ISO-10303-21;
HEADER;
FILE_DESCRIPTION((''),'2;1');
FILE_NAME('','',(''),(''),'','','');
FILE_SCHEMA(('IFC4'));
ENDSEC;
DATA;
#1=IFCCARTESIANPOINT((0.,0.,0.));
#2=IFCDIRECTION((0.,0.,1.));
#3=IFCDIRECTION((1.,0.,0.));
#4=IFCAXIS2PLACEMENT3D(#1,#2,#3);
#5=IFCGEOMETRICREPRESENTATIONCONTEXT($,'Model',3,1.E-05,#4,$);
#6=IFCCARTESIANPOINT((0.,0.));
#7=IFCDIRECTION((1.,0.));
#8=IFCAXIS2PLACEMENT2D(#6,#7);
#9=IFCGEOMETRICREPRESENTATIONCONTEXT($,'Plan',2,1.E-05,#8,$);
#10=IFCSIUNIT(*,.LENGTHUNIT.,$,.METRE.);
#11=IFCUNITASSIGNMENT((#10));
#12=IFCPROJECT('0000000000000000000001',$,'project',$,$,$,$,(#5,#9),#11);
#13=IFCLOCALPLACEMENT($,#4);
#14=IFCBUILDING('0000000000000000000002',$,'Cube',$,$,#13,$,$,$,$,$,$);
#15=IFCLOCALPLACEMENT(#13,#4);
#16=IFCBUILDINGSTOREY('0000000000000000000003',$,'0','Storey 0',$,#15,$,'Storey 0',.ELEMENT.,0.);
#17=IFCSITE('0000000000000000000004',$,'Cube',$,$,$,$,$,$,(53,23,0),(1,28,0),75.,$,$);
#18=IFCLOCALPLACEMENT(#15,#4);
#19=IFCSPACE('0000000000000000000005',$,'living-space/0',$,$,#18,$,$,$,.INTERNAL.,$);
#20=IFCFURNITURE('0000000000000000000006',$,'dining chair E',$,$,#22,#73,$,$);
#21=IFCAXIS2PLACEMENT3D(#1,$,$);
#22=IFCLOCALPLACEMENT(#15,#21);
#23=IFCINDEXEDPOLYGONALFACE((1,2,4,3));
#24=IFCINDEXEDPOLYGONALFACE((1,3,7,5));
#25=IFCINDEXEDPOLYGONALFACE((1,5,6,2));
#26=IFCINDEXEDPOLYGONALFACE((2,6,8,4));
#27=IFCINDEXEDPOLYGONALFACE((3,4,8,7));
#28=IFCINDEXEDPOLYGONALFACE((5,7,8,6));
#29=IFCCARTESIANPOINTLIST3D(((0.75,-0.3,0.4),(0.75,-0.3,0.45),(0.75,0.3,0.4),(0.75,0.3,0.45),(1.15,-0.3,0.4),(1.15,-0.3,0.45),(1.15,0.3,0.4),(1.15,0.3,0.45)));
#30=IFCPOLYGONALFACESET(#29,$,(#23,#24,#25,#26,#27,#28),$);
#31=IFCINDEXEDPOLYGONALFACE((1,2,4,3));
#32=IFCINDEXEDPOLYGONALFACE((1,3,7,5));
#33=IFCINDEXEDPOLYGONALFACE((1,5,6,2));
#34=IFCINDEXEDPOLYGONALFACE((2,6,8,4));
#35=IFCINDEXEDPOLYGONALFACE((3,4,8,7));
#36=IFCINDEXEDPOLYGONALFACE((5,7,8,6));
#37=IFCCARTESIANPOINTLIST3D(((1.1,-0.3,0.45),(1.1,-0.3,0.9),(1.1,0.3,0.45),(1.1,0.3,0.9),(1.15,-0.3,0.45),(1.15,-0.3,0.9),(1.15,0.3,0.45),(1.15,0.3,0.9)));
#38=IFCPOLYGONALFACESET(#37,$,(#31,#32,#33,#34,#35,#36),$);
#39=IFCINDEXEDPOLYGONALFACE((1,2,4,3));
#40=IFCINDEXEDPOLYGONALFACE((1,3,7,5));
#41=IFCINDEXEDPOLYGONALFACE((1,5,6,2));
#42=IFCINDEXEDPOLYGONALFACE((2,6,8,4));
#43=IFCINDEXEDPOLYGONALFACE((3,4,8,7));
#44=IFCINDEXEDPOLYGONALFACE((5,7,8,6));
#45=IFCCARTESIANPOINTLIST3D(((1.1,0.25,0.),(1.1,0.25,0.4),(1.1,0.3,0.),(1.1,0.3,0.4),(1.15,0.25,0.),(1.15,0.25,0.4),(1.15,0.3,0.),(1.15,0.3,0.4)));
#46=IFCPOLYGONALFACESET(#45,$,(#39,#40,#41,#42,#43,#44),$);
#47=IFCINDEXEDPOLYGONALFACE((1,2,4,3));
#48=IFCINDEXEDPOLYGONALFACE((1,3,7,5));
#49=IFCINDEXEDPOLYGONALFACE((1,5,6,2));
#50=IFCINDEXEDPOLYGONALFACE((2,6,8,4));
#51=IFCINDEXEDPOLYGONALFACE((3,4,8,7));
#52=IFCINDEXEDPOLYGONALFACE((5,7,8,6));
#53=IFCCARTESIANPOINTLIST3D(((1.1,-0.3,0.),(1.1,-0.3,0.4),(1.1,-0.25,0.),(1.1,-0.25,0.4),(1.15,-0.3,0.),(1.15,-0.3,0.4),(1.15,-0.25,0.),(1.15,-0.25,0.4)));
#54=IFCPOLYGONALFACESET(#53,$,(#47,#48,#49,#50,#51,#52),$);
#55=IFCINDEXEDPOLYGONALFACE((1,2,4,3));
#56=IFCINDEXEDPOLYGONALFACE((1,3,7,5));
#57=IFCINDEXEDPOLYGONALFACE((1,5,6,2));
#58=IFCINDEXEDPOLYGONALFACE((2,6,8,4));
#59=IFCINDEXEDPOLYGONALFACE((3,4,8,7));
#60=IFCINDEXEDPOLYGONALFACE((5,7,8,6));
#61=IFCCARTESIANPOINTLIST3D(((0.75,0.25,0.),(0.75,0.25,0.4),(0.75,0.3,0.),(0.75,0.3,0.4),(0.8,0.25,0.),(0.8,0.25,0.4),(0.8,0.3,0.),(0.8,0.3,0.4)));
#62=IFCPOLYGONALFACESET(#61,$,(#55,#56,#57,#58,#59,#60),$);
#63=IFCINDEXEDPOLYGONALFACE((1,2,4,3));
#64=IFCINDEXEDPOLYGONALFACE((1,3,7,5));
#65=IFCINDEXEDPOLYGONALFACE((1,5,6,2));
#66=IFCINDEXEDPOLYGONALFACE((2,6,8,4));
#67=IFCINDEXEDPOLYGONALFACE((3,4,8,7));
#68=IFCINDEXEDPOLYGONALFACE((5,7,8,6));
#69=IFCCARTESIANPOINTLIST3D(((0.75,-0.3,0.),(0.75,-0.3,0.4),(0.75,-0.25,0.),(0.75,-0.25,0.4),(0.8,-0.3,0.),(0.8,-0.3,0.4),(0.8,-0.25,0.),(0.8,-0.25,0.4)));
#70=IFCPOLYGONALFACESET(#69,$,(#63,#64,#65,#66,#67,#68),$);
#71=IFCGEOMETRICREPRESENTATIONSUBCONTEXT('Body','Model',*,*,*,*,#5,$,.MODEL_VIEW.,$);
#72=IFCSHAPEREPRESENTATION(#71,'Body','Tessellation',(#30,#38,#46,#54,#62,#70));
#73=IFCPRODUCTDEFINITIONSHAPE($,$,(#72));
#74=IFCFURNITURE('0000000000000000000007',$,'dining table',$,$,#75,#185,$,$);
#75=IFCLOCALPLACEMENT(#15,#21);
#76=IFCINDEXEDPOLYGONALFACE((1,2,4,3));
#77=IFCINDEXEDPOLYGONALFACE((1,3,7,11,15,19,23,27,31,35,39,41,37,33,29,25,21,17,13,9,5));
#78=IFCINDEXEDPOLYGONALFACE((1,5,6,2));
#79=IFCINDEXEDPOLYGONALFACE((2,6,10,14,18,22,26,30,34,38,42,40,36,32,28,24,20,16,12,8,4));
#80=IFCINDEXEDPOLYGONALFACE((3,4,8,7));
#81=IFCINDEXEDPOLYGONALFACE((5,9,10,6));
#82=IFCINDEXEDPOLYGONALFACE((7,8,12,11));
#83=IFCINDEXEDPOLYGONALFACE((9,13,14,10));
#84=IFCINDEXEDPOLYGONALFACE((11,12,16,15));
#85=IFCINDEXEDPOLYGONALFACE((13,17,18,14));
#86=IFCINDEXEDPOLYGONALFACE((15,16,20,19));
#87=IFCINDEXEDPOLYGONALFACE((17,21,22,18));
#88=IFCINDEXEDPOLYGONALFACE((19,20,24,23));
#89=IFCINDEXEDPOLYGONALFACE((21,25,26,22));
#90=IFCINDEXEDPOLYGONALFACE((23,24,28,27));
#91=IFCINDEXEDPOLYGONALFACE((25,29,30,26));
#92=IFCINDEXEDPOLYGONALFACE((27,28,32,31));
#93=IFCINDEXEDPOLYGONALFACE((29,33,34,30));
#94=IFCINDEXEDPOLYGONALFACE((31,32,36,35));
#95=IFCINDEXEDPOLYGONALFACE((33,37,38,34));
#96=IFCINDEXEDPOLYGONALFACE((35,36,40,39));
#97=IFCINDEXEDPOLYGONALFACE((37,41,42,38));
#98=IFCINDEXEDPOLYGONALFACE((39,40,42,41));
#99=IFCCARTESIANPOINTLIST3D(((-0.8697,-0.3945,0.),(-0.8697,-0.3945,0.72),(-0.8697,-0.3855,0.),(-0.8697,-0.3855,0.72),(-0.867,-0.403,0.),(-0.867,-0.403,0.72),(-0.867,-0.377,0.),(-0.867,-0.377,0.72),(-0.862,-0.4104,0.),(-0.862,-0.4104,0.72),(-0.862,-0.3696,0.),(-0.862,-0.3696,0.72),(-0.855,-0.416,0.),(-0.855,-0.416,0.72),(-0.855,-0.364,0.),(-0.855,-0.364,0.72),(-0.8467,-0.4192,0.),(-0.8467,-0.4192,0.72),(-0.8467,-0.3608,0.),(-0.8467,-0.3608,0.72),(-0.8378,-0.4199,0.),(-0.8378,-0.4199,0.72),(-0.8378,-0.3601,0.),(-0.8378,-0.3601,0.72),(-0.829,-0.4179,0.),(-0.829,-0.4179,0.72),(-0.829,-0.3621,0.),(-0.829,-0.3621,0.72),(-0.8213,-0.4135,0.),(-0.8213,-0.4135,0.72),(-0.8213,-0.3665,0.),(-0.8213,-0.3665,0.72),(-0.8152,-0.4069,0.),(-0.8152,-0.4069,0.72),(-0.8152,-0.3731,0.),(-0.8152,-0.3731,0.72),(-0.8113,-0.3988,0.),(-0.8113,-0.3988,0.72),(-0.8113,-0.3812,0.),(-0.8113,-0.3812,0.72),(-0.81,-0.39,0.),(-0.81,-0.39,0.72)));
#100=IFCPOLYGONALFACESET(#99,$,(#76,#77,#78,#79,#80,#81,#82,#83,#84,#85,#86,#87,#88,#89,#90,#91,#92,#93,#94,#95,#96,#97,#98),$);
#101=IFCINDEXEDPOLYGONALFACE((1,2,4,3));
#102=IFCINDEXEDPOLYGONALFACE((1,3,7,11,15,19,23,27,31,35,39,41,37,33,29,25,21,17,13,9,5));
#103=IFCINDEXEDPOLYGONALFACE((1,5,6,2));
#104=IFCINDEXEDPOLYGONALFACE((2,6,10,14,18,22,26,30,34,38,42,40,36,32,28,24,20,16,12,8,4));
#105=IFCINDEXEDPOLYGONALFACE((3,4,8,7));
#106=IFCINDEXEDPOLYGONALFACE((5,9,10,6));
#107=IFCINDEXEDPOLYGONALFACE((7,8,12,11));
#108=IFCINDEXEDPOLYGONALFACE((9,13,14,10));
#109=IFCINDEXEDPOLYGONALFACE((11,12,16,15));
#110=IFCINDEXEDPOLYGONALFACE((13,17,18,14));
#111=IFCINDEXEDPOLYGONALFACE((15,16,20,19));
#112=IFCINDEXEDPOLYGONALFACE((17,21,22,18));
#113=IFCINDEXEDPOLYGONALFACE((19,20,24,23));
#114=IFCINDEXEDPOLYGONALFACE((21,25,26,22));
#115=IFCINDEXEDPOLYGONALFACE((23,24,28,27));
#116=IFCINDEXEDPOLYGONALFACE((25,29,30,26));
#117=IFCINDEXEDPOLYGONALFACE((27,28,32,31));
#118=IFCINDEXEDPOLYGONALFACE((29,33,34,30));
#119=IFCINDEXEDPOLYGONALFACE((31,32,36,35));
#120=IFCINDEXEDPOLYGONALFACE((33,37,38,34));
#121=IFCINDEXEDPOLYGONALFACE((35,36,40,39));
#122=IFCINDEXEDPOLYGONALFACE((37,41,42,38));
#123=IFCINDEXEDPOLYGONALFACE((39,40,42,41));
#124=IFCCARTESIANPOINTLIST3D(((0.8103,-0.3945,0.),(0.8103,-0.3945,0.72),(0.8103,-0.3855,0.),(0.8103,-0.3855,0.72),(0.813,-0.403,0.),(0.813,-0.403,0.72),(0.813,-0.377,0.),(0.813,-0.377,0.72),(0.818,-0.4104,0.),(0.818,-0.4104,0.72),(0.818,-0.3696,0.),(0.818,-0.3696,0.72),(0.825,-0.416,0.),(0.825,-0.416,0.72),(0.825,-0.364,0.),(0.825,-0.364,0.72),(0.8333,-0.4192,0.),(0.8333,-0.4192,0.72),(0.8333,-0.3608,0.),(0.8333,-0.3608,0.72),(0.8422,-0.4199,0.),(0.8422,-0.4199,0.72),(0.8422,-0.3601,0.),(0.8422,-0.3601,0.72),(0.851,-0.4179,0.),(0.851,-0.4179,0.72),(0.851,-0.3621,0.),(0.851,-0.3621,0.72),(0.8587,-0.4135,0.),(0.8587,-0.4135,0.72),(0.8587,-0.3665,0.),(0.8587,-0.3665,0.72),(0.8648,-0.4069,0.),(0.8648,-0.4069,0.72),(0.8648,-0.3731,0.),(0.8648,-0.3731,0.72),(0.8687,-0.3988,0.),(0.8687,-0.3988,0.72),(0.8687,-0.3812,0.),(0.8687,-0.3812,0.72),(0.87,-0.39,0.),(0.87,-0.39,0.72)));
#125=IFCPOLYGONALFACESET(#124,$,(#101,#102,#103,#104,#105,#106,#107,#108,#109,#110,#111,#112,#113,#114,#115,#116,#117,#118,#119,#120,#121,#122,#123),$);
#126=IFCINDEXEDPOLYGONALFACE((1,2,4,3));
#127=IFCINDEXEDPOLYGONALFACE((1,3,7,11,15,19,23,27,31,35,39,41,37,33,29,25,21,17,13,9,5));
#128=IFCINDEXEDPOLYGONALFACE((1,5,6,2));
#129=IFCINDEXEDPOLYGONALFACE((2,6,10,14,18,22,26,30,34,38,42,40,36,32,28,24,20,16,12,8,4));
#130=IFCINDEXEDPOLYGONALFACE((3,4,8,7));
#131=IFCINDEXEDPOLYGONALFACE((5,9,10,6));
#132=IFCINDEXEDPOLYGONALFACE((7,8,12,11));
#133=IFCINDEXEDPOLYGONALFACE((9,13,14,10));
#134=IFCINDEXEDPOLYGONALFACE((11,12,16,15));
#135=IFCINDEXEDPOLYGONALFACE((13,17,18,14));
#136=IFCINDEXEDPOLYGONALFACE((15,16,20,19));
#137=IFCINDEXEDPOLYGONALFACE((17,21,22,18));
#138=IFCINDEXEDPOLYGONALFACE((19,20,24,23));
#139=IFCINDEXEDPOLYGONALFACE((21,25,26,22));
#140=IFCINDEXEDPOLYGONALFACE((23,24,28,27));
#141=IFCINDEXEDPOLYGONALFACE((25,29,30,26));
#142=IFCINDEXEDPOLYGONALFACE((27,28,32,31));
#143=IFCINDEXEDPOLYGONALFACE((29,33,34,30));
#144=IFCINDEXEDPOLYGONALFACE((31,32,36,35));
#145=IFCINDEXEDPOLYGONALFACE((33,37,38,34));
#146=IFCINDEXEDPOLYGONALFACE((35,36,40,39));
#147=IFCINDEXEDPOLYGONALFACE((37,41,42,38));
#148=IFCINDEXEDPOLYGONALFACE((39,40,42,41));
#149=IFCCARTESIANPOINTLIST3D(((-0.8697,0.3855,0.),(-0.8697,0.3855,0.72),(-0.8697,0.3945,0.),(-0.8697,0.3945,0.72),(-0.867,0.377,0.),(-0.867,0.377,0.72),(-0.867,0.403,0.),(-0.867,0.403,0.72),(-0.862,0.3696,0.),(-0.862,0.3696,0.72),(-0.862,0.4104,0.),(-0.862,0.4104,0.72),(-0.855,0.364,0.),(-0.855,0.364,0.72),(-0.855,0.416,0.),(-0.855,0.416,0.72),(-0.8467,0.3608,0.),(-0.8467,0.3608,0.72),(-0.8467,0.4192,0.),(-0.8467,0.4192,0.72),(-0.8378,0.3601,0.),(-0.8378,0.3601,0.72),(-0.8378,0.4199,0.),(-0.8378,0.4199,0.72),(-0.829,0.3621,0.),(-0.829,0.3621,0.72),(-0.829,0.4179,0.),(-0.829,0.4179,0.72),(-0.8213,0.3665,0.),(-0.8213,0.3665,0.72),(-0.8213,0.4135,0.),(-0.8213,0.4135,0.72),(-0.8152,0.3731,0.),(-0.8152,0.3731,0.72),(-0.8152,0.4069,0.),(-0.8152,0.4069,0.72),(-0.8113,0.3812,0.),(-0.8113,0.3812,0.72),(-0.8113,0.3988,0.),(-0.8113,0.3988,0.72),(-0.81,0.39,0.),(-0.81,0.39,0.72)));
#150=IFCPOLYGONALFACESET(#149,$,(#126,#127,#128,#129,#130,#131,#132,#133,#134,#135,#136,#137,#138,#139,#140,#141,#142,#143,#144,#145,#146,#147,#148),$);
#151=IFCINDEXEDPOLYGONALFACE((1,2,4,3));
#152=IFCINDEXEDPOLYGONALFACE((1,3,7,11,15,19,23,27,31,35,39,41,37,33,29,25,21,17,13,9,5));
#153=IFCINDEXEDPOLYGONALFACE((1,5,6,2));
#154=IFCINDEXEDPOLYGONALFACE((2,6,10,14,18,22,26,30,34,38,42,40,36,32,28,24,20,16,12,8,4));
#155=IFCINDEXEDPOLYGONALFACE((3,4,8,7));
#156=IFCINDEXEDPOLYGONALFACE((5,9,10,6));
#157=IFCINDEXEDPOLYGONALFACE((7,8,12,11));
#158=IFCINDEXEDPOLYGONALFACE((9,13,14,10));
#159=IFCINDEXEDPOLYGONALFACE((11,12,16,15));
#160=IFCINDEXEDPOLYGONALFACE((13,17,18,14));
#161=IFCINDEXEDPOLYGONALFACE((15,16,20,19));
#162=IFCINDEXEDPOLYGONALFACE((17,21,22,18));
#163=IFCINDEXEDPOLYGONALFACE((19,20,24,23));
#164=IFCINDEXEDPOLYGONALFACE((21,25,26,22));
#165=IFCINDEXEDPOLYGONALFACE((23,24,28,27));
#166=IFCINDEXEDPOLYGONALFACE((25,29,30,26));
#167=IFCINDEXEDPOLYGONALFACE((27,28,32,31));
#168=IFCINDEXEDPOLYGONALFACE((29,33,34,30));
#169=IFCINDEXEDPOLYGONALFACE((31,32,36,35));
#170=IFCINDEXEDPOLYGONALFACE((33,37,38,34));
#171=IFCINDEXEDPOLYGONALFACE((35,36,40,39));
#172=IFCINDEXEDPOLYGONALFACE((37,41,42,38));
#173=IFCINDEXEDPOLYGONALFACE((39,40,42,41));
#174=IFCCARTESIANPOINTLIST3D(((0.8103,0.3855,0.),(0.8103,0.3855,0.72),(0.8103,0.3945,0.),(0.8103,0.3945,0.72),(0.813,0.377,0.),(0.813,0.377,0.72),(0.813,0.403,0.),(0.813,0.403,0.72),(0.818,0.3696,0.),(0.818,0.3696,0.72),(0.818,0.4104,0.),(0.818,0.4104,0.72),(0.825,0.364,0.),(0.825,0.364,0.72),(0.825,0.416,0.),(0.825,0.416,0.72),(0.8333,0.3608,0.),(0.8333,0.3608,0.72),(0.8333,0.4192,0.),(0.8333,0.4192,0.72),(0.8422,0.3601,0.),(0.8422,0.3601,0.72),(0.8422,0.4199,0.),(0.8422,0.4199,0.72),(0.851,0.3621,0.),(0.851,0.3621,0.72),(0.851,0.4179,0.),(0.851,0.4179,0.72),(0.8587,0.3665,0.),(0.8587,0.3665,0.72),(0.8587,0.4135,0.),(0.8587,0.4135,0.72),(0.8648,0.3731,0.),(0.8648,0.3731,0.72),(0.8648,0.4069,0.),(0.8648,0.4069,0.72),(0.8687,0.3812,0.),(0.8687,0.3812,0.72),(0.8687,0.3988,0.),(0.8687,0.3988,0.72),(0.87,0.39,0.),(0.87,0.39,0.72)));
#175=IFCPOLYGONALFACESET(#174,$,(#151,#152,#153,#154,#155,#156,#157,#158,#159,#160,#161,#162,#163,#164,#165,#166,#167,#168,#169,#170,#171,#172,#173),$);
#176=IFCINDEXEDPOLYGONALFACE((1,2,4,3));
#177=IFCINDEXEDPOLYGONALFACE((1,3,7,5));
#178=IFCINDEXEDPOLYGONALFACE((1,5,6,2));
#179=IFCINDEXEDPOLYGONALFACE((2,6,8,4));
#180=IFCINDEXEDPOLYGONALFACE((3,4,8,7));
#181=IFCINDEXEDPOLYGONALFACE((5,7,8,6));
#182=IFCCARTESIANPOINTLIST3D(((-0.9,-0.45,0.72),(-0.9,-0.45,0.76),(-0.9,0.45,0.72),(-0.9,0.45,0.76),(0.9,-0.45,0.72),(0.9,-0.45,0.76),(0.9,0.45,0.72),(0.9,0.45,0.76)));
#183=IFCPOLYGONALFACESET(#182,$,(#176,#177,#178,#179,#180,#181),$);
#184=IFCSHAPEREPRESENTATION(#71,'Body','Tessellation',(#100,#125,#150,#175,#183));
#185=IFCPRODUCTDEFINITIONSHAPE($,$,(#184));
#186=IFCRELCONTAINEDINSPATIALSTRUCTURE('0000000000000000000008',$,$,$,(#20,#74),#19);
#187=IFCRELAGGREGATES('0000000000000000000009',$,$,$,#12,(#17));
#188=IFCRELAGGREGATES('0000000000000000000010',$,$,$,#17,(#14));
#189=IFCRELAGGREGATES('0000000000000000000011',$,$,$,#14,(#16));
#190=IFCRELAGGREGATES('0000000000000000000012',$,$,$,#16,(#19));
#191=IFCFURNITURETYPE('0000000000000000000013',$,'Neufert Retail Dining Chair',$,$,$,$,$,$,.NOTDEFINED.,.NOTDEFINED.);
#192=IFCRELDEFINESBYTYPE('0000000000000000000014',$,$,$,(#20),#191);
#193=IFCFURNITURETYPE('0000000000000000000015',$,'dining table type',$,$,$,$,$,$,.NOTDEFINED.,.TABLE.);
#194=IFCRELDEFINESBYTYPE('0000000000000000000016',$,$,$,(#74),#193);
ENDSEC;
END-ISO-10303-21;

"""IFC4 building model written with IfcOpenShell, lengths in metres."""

from ifc_helpers import new_model, entity, si_unit, frame, origin_with_axes, origin_2d_with_axis, place, context, subcontext, project, spatial, line, indexed_curve, outline, extrude, shape, source, transform, mapped, type_object, type_shapes, element, save


model = new_model("IFC4")

# Units and contexts
model_context = context("Model", 3, precision=1e-05, world=origin_with_axes())
plan_context = context("Plan", 2, precision=1e-05, world=origin_2d_with_axis())
body_context_1 = subcontext(model_context, "Body", "Model", "MODEL_VIEW")
body_context_2 = subcontext(plan_context, "Body", "Plan", "PLAN_VIEW")
ifc_project = project(units=[si_unit("LENGTHUNIT", "METRE")], contexts=[model_context, plan_context])

# Site, building, storey
site = spatial("IfcSite", under=ifc_project, Name="Cube", RefLatitude=(53, 23, 0), RefLongitude=(1, 28, 0), RefElevation=75.0)
building_placement = place(None, origin_with_axes())
building = spatial("IfcBuilding", under=site, at=building_placement, Name="Cube")
storey_placement = place(building_placement, origin_with_axes())
storey = spatial("IfcBuildingStorey", under=building, at=storey_placement, Name="0", Description="Storey 0", LongName="Storey 0", CompositionType="ELEMENT", Elevation=0.0)

# Shared definitions
space_placement = place(storey_placement, origin_with_axes())
space = spatial("IfcSpace", under=storey, at=space_placement, Name="living-space/0", PredefinedType="INTERNAL")

# Furniture
furniture_type_1 = type_object("IfcFurnitureType", Name="Neufert Retail Dining Chair", AssemblyPlace="NOTDEFINED", PredefinedType="NOTDEFINED")
shared_shape_1 = source(origin_with_axes(), body_context_1, "Body", "SweptSolid", [
    extrude(outline(indexed_curve([(-0.3, 0.0), (0.3, 0.0), (0.3, -0.4), (-0.3, -0.4)], segments=[line(1, 2, 3, 4, 1)])), frame((0.0, 0.0, 0.45), z_axis=(0.0, 0.0, 1.0), x_axis=(1.0, 0.0, 0.0)), (0.0, 0.0, -1.0), 0.05),
    extrude(outline(indexed_curve([(-0.3, 0.0), (0.3, 0.0), (0.3, -0.05), (-0.3, -0.05)], segments=[line(1, 2, 3, 4, 1)])), frame((0.0, 0.0, 0.9), z_axis=(0.0, 0.0, 1.0), x_axis=(1.0, 0.0, 0.0)), (0.0, 0.0, -1.0), 0.45),
    extrude(outline(indexed_curve([(-0.3, 0.0), (-0.25, 0.0), (-0.25, -0.05), (-0.3, -0.05)], segments=[line(1, 2, 3, 4, 1)])), origin_with_axes(), (0.0, 0.0, 1.0), 0.4),
    extrude(outline(indexed_curve([(0.3, 0.0), (0.25, 0.0), (0.25, -0.05), (0.3, -0.05)], segments=[line(1, 2, 3, 4, 1)])), origin_with_axes(), (0.0, 0.0, 1.0), 0.4),
    extrude(outline(indexed_curve([(-0.3, -0.4), (-0.25, -0.4), (-0.25, -0.35), (-0.3, -0.35)], segments=[line(1, 2, 3, 4, 1)])), origin_with_axes(), (0.0, 0.0, 1.0), 0.4),
    extrude(outline(indexed_curve([(0.3, -0.4), (0.25, -0.4), (0.25, -0.35), (0.3, -0.35)], segments=[line(1, 2, 3, 4, 1)])), origin_with_axes(), (0.0, 0.0, 1.0), 0.4),
])
shared_shape_2 = source(origin_with_axes(), body_context_2, "Body", "Curve2D", [
    entity("IfcIndexedPolyCurve", entity("IfcCartesianPointList2D", [[-0.3, -0.4], [0.3, -0.4]])),
    entity("IfcIndexedPolyCurve", entity("IfcCartesianPointList2D", [[-0.3, -0.4], [-0.3, -0.3], [-0.2121, -0.0879], [0.0, 0.0], [0.2121, -0.0879], [0.3, -0.3], [0.3, -0.4]]), [entity("IfcLineIndex", [1, 2]), entity("IfcArcIndex", [2, 3, 4]), entity("IfcArcIndex", [4, 5, 6]), entity("IfcLineIndex", [6, 7])]),
    entity("IfcIndexedPolyCurve", entity("IfcCartesianPointList2D", [[-0.26, -0.4], [-0.26, -0.3], [-0.1838, -0.1162], [0.0, -0.04], [0.1838, -0.1162], [0.26, -0.3], [0.26, -0.4]]), [entity("IfcLineIndex", [1, 2]), entity("IfcArcIndex", [2, 3, 4]), entity("IfcArcIndex", [4, 5, 6]), entity("IfcLineIndex", [6, 7])]),
])
type_shapes(furniture_type_1, [shared_shape_1, shared_shape_2])
for number, where, z_axis, x_axis, name in (
    (1, (1.15, 0.0, 0.0), (0.0, 0.0, 1.0), (0.0, -1.0, 0.0), "dining chair E"),
):
    element("IfcFurniture", number, at=place(space_placement, frame(where, z_axis=z_axis, x_axis=x_axis)), inside=space, type_object=furniture_type_1, Name=name, shapes=[
        shape(body_context_1, "Body", "MappedRepresentation", [mapped(shared_shape_1, transform((0.0, 0.0, 0.0), x_axis=(1.0, 0.0, 0.0), y_axis=(0.0, 1.0, 0.0), z_axis=(0.0, 0.0, 1.0), scale=1.0))]),
        shape(body_context_2, "Body", "MappedRepresentation", [mapped(shared_shape_2, transform((0.0, 0.0, 0.0), x_axis=(1.0, 0.0, 0.0), y_axis=(0.0, 1.0, 0.0), z_axis=(0.0, 0.0, 1.0), scale=1.0))]),
    ])
furniture_type_2 = type_object("IfcFurnitureType", Name="dining table type", AssemblyPlace="NOTDEFINED", PredefinedType="TABLE")
shared_circle = entity("IfcCircle", entity("IfcAxis2Placement2D", entity("IfcCartesianPoint", [0.0, 0.0])), 0.03)
shared_shape_3 = source(origin_with_axes(), body_context_1, "Body", "SweptSolid", [
    entity("IfcExtrudedAreaSolid", entity("IfcArbitraryClosedProfileDef", "AREA", None, shared_circle), entity("IfcAxis2Placement3D", entity("IfcCartesianPoint", [-0.84, -0.39, 0.0]), entity("IfcDirection", [0.0, 0.0, 1.0]), entity("IfcDirection", [1.0, 0.0, 0.0])), entity("IfcDirection", [0.0, 0.0, 1.0]), 0.72),
    entity("IfcExtrudedAreaSolid", entity("IfcArbitraryClosedProfileDef", "AREA", None, shared_circle), entity("IfcAxis2Placement3D", entity("IfcCartesianPoint", [0.84, -0.39, 0.0]), entity("IfcDirection", [0.0, 0.0, 1.0]), entity("IfcDirection", [1.0, 0.0, 0.0])), entity("IfcDirection", [0.0, 0.0, 1.0]), 0.72),
    entity("IfcExtrudedAreaSolid", entity("IfcArbitraryClosedProfileDef", "AREA", None, shared_circle), entity("IfcAxis2Placement3D", entity("IfcCartesianPoint", [-0.84, 0.39, 0.0]), entity("IfcDirection", [0.0, 0.0, 1.0]), entity("IfcDirection", [1.0, 0.0, 0.0])), entity("IfcDirection", [0.0, 0.0, 1.0]), 0.72),
    entity("IfcExtrudedAreaSolid", entity("IfcArbitraryClosedProfileDef", "AREA", None, shared_circle), entity("IfcAxis2Placement3D", entity("IfcCartesianPoint", [0.84, 0.39, 0.0]), entity("IfcDirection", [0.0, 0.0, 1.0]), entity("IfcDirection", [1.0, 0.0, 0.0])), entity("IfcDirection", [0.0, 0.0, 1.0]), 0.72),
    extrude(outline(indexed_curve([(-0.9, -0.45), (0.9, -0.45), (0.9, 0.45), (-0.9, 0.45)], segments=[line(1, 2, 3, 4, 1)])), frame((0.0, 0.0, 0.72), z_axis=(0.0, 0.0, 1.0), x_axis=(1.0, 0.0, 0.0)), (0.0, 0.0, 1.0), 0.04),
])
type_shapes(furniture_type_2, [shared_shape_3])
furniture_placement = place(space_placement, origin_with_axes())
element("IfcFurniture", 2, at=furniture_placement, inside=space, type_object=furniture_type_2, Name="dining table", context=body_context_1, shape_type="MappedRepresentation", body=[
    mapped(shared_shape_3, transform((0.0, 0.0, 0.0), x_axis=(1.0, 0.0, 0.0), y_axis=(0.0, 1.0, 0.0), z_axis=(0.0, 0.0, 1.0), scale=1.0)),
])

save(model, "model.ifc")
